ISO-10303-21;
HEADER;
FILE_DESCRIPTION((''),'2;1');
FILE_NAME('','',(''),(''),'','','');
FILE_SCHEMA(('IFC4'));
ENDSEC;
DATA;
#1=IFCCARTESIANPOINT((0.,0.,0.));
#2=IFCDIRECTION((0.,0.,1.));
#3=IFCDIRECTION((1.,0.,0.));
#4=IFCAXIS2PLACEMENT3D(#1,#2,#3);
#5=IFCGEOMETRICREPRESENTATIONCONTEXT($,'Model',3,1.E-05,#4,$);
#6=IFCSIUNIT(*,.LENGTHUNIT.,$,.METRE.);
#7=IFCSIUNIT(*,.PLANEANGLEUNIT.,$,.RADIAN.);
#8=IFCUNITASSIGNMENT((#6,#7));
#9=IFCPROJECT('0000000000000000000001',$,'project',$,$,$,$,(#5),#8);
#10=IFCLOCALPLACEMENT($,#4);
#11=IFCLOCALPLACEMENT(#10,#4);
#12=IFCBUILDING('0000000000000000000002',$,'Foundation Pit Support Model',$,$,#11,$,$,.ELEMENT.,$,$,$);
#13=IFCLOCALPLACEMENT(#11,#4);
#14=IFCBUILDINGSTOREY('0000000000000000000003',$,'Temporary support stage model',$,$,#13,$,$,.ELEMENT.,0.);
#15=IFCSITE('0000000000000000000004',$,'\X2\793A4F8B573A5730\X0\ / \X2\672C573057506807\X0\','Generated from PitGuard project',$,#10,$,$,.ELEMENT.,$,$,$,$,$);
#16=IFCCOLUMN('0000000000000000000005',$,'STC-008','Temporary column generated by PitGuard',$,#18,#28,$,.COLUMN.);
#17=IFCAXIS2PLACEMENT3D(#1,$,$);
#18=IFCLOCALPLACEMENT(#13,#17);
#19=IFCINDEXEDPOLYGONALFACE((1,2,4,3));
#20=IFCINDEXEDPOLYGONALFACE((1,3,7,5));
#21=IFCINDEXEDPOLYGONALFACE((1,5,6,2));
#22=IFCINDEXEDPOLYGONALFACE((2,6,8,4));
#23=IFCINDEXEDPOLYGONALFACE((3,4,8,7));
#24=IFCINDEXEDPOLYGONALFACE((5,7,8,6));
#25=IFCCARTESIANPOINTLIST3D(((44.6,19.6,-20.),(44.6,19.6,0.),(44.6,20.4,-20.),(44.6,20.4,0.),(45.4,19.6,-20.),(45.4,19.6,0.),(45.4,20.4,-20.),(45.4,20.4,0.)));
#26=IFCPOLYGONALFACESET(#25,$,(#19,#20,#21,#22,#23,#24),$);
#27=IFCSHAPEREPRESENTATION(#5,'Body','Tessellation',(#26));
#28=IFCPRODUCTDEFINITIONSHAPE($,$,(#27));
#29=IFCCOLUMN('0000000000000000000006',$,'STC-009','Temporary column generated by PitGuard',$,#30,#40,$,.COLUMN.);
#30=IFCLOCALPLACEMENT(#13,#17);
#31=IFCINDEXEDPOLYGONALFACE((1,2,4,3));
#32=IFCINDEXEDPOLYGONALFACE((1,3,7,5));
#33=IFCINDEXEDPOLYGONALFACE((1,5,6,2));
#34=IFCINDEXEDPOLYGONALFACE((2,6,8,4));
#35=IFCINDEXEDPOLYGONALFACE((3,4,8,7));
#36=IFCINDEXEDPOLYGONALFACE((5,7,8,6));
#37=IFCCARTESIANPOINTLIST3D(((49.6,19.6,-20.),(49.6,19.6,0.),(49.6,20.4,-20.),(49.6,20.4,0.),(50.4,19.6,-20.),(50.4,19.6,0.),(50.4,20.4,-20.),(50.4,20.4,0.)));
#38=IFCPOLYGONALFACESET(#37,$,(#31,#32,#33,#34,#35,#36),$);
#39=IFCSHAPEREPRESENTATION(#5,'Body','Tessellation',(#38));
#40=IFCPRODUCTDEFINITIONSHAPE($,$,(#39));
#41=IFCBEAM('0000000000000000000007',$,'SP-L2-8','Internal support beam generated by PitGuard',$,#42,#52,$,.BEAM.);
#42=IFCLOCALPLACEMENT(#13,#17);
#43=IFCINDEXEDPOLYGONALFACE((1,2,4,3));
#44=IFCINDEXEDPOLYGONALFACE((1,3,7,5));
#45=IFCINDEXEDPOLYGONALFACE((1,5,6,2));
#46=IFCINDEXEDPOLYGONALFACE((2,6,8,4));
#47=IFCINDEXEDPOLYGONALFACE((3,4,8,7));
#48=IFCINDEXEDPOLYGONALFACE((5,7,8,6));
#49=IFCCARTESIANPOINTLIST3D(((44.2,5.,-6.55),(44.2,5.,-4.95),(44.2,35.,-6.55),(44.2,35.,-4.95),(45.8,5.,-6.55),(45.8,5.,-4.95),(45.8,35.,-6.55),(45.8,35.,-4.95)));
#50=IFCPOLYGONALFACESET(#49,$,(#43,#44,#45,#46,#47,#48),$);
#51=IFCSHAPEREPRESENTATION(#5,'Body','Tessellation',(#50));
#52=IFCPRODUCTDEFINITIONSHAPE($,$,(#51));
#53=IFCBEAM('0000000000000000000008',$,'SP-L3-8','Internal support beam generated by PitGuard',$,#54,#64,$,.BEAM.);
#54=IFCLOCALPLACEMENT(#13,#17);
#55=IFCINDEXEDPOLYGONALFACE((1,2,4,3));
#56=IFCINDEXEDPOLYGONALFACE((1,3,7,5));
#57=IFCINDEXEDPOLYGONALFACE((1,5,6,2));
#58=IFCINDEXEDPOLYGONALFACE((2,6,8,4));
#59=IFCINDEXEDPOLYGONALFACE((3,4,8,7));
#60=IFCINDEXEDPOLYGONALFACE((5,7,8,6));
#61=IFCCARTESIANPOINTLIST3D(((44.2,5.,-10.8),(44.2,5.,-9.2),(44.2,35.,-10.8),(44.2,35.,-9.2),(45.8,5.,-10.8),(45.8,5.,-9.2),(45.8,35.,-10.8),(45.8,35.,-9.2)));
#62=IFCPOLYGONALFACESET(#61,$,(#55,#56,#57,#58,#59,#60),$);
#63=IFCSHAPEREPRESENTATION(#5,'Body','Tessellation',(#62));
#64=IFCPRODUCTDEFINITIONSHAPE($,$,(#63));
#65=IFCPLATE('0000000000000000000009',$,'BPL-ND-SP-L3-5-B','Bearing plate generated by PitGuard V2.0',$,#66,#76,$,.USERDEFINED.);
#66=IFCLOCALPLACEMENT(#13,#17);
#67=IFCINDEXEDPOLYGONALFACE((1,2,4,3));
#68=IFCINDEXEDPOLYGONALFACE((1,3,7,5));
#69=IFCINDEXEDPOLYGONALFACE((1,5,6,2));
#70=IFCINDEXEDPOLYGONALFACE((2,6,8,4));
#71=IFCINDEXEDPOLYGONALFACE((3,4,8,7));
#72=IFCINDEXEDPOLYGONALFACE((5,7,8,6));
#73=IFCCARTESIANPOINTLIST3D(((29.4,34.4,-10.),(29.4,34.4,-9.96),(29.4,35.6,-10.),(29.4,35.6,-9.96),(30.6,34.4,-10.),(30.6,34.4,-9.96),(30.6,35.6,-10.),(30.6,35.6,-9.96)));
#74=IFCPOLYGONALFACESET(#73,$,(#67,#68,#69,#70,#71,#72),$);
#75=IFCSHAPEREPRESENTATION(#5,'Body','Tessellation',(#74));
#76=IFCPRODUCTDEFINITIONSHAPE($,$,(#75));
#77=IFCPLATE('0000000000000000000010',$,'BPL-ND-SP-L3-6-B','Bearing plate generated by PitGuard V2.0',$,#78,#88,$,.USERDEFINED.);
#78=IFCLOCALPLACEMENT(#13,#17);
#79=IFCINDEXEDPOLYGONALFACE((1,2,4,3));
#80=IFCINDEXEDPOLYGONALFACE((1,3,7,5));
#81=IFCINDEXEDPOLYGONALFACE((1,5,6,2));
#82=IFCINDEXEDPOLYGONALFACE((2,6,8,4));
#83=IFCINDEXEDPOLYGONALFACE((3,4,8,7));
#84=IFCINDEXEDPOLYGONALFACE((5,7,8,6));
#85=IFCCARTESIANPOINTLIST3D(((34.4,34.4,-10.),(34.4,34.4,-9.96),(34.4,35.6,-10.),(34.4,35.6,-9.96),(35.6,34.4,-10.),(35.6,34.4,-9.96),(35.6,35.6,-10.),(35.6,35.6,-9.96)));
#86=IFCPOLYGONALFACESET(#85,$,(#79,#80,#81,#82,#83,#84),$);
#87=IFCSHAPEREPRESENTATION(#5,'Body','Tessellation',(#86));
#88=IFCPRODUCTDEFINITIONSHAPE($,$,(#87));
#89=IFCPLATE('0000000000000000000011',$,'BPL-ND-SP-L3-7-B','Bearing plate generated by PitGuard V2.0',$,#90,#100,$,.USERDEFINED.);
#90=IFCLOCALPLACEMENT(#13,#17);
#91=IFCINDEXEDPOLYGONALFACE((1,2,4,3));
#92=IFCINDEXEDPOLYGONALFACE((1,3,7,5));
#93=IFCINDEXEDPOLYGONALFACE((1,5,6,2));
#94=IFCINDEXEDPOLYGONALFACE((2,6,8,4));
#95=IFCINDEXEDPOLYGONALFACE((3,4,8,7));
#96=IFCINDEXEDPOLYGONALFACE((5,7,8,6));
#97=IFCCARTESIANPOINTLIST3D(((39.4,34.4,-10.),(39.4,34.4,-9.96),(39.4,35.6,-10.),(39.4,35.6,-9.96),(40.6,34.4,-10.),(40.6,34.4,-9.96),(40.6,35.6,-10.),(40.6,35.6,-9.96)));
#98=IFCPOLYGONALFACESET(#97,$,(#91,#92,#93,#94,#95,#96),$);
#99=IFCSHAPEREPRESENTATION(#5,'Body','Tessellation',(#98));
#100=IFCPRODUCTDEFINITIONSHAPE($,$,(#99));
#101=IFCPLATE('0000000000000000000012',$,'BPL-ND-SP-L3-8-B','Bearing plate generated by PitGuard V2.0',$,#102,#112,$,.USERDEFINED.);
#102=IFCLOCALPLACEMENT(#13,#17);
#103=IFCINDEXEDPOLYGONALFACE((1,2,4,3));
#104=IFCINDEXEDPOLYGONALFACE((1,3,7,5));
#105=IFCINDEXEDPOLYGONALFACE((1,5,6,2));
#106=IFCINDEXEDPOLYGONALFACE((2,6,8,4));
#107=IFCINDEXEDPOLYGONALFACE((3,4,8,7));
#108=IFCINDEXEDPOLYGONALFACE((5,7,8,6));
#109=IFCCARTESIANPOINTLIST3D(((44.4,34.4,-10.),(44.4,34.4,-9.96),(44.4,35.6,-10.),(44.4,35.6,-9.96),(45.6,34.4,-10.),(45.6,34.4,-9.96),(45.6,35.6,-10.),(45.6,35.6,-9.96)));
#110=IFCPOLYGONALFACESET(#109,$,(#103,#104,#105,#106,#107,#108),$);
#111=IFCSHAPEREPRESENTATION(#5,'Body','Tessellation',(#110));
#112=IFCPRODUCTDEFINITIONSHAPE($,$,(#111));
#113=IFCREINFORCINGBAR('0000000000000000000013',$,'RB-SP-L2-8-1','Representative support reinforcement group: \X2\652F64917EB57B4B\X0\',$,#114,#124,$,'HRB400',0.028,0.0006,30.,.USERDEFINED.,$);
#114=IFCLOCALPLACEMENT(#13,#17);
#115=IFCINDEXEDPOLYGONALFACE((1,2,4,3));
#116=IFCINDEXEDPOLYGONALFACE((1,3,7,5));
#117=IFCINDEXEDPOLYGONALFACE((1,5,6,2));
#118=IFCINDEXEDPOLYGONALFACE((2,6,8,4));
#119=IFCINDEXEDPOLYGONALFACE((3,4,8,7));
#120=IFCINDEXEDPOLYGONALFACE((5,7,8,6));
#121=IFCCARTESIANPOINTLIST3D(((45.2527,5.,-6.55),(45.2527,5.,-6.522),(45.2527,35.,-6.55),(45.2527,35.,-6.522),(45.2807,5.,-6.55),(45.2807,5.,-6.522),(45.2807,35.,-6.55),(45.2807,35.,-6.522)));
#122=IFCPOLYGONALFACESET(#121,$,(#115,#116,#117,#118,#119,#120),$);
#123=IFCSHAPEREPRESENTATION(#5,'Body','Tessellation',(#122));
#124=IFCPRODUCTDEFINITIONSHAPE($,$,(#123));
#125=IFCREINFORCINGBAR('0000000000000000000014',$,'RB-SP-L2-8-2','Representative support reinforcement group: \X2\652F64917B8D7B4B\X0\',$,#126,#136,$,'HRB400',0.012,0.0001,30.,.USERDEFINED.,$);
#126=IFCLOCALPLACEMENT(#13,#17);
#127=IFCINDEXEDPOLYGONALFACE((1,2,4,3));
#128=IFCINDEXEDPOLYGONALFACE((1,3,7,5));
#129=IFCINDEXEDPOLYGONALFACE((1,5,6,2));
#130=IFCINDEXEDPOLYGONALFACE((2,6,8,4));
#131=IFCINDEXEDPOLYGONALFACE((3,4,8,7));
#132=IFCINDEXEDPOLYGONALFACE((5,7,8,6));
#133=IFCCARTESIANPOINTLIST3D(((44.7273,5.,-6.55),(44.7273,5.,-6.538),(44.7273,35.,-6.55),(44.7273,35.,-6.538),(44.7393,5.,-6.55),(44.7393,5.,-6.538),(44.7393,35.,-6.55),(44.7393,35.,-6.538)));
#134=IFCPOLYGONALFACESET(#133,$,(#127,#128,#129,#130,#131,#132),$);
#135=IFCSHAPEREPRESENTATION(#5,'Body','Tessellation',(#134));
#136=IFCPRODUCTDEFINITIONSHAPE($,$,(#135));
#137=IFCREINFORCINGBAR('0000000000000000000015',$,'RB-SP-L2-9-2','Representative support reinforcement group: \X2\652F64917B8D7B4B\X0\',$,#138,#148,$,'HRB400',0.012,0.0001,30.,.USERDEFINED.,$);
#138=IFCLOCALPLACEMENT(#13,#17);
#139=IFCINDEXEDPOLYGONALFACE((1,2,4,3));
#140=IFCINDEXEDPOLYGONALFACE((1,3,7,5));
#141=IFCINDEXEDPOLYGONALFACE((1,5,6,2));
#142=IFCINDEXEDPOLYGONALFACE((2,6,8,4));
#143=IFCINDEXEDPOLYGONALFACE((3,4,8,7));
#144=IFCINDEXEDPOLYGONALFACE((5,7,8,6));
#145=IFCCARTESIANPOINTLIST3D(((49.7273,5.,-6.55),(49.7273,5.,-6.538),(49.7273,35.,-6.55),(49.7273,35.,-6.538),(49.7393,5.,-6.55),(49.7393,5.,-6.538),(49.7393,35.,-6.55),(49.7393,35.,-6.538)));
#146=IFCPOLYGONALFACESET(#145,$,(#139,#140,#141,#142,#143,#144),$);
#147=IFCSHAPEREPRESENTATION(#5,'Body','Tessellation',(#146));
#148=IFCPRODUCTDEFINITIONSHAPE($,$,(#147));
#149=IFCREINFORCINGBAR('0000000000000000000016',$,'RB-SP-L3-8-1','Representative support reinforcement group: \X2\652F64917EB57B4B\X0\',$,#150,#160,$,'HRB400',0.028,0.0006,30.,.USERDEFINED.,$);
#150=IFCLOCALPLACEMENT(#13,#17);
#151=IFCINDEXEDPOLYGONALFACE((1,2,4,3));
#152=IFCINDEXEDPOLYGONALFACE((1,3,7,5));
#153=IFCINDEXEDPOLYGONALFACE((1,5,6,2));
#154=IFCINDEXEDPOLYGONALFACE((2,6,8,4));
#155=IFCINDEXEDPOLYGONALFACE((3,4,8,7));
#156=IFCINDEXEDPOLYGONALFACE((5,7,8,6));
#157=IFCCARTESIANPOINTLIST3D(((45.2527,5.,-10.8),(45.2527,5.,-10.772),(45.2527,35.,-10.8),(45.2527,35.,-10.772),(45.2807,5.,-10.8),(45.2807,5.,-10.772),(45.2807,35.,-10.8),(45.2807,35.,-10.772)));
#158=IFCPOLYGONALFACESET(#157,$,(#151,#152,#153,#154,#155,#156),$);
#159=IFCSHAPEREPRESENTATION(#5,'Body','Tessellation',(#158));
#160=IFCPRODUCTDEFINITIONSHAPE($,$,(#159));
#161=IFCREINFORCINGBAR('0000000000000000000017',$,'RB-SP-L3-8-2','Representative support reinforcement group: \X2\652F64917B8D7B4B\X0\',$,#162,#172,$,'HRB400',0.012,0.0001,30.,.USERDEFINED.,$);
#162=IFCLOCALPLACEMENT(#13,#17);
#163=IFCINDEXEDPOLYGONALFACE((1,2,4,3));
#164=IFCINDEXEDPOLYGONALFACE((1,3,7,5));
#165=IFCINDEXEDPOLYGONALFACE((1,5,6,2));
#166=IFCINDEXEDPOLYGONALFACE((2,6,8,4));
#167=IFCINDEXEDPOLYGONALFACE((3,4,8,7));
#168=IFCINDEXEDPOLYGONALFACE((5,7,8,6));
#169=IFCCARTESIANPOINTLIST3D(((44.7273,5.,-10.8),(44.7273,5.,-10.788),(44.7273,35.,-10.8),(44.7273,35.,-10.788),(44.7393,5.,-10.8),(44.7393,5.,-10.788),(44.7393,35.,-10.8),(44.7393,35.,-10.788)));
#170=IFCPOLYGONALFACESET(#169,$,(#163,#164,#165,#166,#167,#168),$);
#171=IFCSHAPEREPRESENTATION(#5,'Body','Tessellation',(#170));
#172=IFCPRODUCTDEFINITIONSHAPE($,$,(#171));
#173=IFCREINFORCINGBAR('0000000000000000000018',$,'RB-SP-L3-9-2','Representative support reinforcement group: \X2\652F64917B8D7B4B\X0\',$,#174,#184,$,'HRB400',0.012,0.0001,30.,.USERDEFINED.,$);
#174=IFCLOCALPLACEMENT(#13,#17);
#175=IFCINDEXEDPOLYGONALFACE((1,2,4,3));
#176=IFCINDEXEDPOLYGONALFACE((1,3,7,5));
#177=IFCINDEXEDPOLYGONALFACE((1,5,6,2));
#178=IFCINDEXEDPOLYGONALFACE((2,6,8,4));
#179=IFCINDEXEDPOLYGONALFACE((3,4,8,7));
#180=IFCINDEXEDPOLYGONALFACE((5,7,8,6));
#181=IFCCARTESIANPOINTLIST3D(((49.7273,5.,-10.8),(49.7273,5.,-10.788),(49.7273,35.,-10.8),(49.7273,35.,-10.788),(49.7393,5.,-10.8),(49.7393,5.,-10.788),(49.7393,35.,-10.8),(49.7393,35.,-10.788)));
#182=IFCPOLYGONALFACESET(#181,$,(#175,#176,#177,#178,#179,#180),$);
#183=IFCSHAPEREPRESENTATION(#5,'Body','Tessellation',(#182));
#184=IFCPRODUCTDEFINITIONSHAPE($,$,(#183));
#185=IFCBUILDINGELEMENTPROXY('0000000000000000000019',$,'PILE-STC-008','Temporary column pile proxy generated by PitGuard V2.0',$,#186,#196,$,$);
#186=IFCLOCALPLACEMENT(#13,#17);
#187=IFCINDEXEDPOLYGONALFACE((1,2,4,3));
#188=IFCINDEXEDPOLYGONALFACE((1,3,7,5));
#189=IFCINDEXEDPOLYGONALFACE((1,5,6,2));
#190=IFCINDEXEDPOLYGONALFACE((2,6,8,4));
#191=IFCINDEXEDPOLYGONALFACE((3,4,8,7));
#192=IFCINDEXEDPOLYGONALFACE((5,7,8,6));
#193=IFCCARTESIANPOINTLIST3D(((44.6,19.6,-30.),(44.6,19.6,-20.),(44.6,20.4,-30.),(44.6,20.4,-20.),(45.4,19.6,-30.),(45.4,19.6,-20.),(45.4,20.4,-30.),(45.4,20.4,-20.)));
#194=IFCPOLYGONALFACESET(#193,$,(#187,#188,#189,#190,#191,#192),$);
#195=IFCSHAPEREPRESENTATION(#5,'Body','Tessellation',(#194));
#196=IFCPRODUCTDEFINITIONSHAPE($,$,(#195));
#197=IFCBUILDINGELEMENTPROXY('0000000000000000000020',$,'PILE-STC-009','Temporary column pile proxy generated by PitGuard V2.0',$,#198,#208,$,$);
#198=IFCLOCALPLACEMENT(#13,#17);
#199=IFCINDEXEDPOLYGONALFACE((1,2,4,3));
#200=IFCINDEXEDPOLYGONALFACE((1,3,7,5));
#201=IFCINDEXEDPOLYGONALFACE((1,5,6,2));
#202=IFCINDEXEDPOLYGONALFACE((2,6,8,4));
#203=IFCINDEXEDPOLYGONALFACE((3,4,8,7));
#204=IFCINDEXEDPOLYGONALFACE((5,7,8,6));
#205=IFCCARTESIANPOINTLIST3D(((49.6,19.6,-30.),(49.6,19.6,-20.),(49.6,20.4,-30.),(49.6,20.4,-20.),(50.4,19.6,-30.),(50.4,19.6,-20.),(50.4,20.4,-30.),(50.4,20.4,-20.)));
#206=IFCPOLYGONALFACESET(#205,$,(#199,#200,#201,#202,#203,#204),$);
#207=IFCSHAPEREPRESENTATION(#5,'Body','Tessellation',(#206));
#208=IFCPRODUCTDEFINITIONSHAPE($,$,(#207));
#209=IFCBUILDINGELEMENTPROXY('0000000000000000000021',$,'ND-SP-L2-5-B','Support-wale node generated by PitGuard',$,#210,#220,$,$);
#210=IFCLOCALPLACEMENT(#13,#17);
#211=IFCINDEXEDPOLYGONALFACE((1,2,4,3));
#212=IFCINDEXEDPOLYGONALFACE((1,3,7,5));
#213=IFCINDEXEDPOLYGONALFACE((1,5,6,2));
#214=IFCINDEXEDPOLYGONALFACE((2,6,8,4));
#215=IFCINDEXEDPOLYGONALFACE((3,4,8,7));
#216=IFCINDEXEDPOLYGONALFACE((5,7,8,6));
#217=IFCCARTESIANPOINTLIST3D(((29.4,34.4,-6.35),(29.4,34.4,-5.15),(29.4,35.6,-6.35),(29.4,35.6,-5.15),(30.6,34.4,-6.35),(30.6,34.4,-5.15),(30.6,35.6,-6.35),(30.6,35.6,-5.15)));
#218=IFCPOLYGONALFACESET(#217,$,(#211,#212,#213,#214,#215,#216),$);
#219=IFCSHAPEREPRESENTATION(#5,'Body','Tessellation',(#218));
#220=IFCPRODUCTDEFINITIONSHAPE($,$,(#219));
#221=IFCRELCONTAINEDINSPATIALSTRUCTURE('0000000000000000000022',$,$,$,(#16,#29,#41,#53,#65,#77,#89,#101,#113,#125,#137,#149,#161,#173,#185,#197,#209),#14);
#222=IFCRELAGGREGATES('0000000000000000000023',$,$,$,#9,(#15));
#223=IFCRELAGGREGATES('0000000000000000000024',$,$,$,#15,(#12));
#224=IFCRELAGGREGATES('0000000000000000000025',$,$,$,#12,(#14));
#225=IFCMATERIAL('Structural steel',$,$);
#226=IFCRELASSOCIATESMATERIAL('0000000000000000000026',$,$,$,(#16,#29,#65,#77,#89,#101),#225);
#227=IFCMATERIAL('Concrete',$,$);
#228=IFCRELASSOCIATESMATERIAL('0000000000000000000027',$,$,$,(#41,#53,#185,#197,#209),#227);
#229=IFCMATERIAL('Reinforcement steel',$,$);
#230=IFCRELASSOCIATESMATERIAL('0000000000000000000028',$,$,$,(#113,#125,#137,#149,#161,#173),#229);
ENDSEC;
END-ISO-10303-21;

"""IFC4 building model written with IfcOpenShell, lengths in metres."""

from ifc_helpers import new_model, si_unit, frame, origin_with_axes, origin_2d, place, context, project, spatial, rectangle, extrude, material, element, save


model = new_model("IFC4")

# Units and contexts
model_context = context("Model", 3, precision=1e-05, world=origin_with_axes())
ifc_project = project(units=[si_unit("LENGTHUNIT", "METRE"), si_unit("PLANEANGLEUNIT", "RADIAN")], contexts=[model_context])

# Site, building, storey
site_placement = place(None, origin_with_axes())
site = spatial("IfcSite", under=ifc_project, at=site_placement, Name="示例场地 / 本地坐标", Description="Generated from PitGuard project", CompositionType="ELEMENT")
building_placement = place(site_placement, origin_with_axes())
building = spatial("IfcBuilding", under=site, at=building_placement, Name="Foundation Pit Support Model", CompositionType="ELEMENT")
storey_placement = place(building_placement, origin_with_axes())
storey = spatial("IfcBuildingStorey", under=building, at=storey_placement, Name="Temporary support stage model", CompositionType="ELEMENT", Elevation=0.0)

# Columns
ifc_material_1 = material(Name="Structural steel")
for number, where, z_axis, x_axis, name in (
    (1, (45.0, 20.0, -20.0), (0.0, 0.0, 1.0), (1.0, 0.0, 0.0), "STC-008"),
    (2, (50.0, 20.0, -20.0), (0.0, 0.0, 1.0), (1.0, 0.0, 0.0), "STC-009"),
):
    element("IfcColumn", number, at=place(storey_placement, frame(where, z_axis=z_axis, x_axis=x_axis)), inside=storey, material=ifc_material_1, Name=name, Description="Temporary column generated by PitGuard", PredefinedType="COLUMN", context=model_context, shape_type="SweptSolid", body=[
        extrude(rectangle(XDim=0.8, YDim=0.8, at=origin_2d()), origin_with_axes(), (0.0, 0.0, 1.0), 20.0),
    ])

# Beams
ifc_material_2 = material(Name="Concrete")
for number, where, z_axis, x_axis, name in (
    (3, (45.0, 20.0, -6.55), (0.0, 0.0, 1.0), (0.0, 1.0, 0.0), "SP-L2-8"),
    (4, (45.0, 20.0, -10.8), (0.0, 0.0, 1.0), (0.0, 1.0, 0.0), "SP-L3-8"),
):
    element("IfcBeam", number, at=place(storey_placement, frame(where, z_axis=z_axis, x_axis=x_axis)), inside=storey, material=ifc_material_2, Name=name, Description="Internal support beam generated by PitGuard", PredefinedType="BEAM", context=model_context, shape_type="SweptSolid", body=[
        extrude(rectangle(XDim=30.0, YDim=1.6, at=origin_2d()), origin_with_axes(), (0.0, 0.0, 1.0), 1.6),
    ])

# Plates
for number, where, z_axis, x_axis, name in (
    (5, (30.0, 35.0, -10.0), (0.0, 0.0, 1.0), (1.0, 0.0, 0.0), "BPL-ND-SP-L3-5-B"),
    (6, (35.0, 35.0, -10.0), (0.0, 0.0, 1.0), (1.0, 0.0, 0.0), "BPL-ND-SP-L3-6-B"),
    (7, (40.0, 35.0, -10.0), (0.0, 0.0, 1.0), (1.0, 0.0, 0.0), "BPL-ND-SP-L3-7-B"),
    (8, (45.0, 35.0, -10.0), (0.0, 0.0, 1.0), (1.0, 0.0, 0.0), "BPL-ND-SP-L3-8-B"),
):
    element("IfcPlate", number, at=place(storey_placement, frame(where, z_axis=z_axis, x_axis=x_axis)), inside=storey, material=ifc_material_1, Name=name, Description="Bearing plate generated by PitGuard V2.0", PredefinedType="USERDEFINED", context=model_context, shape_type="SweptSolid", body=[
        extrude(rectangle(XDim=1.2, YDim=1.2, at=origin_2d()), origin_with_axes(), (0.0, 0.0, 1.0), 0.04),
    ])

# Reinforcing bars
ifc_material_3 = material(Name="Reinforcement steel")
reinforcing_bar_1_placement = place(storey_placement, frame((45.2667, 20.0, -6.55), z_axis=(0.0, 0.0, 1.0), x_axis=(0.0, 1.0, 0.0)))
element("IfcReinforcingBar", 9, at=reinforcing_bar_1_placement, inside=storey, material=ifc_material_3, Name="RB-SP-L2-8-1", Description="Representative support reinforcement group: 支撑纵筋", SteelGrade="HRB400", BarLength=30.0, CrossSectionArea=0.0006, NominalDiameter=0.028, PredefinedType="USERDEFINED", context=model_context, shape_type="SweptSolid", body=[
    extrude(rectangle(XDim=30.0, YDim=0.028, at=origin_2d()), origin_with_axes(), (0.0, 0.0, 1.0), 0.028),
])
for number, where, z_axis, x_axis, name in (
    (10, (44.7333, 20.0, -6.55), (0.0, 0.0, 1.0), (0.0, 1.0, 0.0), "RB-SP-L2-8-2"),
    (11, (49.7333, 20.0, -6.55), (0.0, 0.0, 1.0), (0.0, 1.0, 0.0), "RB-SP-L2-9-2"),
):
    element("IfcReinforcingBar", number, at=place(storey_placement, frame(where, z_axis=z_axis, x_axis=x_axis)), inside=storey, material=ifc_material_3, Name=name, Description="Representative support reinforcement group: 支撑箍筋", SteelGrade="HRB400", BarLength=30.0, CrossSectionArea=0.0001, NominalDiameter=0.012, PredefinedType="USERDEFINED", context=model_context, shape_type="SweptSolid", body=[
        extrude(rectangle(XDim=30.0, YDim=0.012, at=origin_2d()), origin_with_axes(), (0.0, 0.0, 1.0), 0.012),
    ])
reinforcing_bar_2_placement = place(storey_placement, frame((45.2667, 20.0, -10.8), z_axis=(0.0, 0.0, 1.0), x_axis=(0.0, 1.0, 0.0)))
element("IfcReinforcingBar", 12, at=reinforcing_bar_2_placement, inside=storey, material=ifc_material_3, Name="RB-SP-L3-8-1", Description="Representative support reinforcement group: 支撑纵筋", SteelGrade="HRB400", BarLength=30.0, CrossSectionArea=0.0006, NominalDiameter=0.028, PredefinedType="USERDEFINED", context=model_context, shape_type="SweptSolid", body=[
    extrude(rectangle(XDim=30.0, YDim=0.028, at=origin_2d()), origin_with_axes(), (0.0, 0.0, 1.0), 0.028),
])
for number, where, z_axis, x_axis, name in (
    (13, (44.7333, 20.0, -10.8), (0.0, 0.0, 1.0), (0.0, 1.0, 0.0), "RB-SP-L3-8-2"),
    (14, (49.7333, 20.0, -10.8), (0.0, 0.0, 1.0), (0.0, 1.0, 0.0), "RB-SP-L3-9-2"),
):
    element("IfcReinforcingBar", number, at=place(storey_placement, frame(where, z_axis=z_axis, x_axis=x_axis)), inside=storey, material=ifc_material_3, Name=name, Description="Representative support reinforcement group: 支撑箍筋", SteelGrade="HRB400", BarLength=30.0, CrossSectionArea=0.0001, NominalDiameter=0.012, PredefinedType="USERDEFINED", context=model_context, shape_type="SweptSolid", body=[
        extrude(rectangle(XDim=30.0, YDim=0.012, at=origin_2d()), origin_with_axes(), (0.0, 0.0, 1.0), 0.012),
    ])

# Building element proxies
for number, where, z_axis, x_axis, name in (
    (15, (45.0, 20.0, -30.0), (0.0, 0.0, 1.0), (1.0, 0.0, 0.0), "PILE-STC-008"),
    (16, (50.0, 20.0, -30.0), (0.0, 0.0, 1.0), (1.0, 0.0, 0.0), "PILE-STC-009"),
):
    element("IfcBuildingElementProxy", number, at=place(storey_placement, frame(where, z_axis=z_axis, x_axis=x_axis)), inside=storey, material=ifc_material_2, Name=name, Description="Temporary column pile proxy generated by PitGuard V2.0", context=model_context, shape_type="SweptSolid", body=[
        extrude(rectangle(XDim=0.8, YDim=0.8, at=origin_2d()), origin_with_axes(), (0.0, 0.0, 1.0), 10.0),
    ])
for number, where, z_axis, x_axis, name in (
    (17, (30.0, 35.0, -6.35), (0.0, 0.0, 1.0), (1.0, 0.0, 0.0), "ND-SP-L2-5-B"),
):
    element("IfcBuildingElementProxy", number, at=place(storey_placement, frame(where, z_axis=z_axis, x_axis=x_axis)), inside=storey, material=ifc_material_2, Name=name, Description="Support-wale node generated by PitGuard", context=model_context, shape_type="SweptSolid", body=[
        extrude(rectangle(XDim=1.2, YDim=1.2, at=origin_2d()), origin_with_axes(), (0.0, 0.0, 1.0), 1.2),
    ])

save(model, "model.ifc")
